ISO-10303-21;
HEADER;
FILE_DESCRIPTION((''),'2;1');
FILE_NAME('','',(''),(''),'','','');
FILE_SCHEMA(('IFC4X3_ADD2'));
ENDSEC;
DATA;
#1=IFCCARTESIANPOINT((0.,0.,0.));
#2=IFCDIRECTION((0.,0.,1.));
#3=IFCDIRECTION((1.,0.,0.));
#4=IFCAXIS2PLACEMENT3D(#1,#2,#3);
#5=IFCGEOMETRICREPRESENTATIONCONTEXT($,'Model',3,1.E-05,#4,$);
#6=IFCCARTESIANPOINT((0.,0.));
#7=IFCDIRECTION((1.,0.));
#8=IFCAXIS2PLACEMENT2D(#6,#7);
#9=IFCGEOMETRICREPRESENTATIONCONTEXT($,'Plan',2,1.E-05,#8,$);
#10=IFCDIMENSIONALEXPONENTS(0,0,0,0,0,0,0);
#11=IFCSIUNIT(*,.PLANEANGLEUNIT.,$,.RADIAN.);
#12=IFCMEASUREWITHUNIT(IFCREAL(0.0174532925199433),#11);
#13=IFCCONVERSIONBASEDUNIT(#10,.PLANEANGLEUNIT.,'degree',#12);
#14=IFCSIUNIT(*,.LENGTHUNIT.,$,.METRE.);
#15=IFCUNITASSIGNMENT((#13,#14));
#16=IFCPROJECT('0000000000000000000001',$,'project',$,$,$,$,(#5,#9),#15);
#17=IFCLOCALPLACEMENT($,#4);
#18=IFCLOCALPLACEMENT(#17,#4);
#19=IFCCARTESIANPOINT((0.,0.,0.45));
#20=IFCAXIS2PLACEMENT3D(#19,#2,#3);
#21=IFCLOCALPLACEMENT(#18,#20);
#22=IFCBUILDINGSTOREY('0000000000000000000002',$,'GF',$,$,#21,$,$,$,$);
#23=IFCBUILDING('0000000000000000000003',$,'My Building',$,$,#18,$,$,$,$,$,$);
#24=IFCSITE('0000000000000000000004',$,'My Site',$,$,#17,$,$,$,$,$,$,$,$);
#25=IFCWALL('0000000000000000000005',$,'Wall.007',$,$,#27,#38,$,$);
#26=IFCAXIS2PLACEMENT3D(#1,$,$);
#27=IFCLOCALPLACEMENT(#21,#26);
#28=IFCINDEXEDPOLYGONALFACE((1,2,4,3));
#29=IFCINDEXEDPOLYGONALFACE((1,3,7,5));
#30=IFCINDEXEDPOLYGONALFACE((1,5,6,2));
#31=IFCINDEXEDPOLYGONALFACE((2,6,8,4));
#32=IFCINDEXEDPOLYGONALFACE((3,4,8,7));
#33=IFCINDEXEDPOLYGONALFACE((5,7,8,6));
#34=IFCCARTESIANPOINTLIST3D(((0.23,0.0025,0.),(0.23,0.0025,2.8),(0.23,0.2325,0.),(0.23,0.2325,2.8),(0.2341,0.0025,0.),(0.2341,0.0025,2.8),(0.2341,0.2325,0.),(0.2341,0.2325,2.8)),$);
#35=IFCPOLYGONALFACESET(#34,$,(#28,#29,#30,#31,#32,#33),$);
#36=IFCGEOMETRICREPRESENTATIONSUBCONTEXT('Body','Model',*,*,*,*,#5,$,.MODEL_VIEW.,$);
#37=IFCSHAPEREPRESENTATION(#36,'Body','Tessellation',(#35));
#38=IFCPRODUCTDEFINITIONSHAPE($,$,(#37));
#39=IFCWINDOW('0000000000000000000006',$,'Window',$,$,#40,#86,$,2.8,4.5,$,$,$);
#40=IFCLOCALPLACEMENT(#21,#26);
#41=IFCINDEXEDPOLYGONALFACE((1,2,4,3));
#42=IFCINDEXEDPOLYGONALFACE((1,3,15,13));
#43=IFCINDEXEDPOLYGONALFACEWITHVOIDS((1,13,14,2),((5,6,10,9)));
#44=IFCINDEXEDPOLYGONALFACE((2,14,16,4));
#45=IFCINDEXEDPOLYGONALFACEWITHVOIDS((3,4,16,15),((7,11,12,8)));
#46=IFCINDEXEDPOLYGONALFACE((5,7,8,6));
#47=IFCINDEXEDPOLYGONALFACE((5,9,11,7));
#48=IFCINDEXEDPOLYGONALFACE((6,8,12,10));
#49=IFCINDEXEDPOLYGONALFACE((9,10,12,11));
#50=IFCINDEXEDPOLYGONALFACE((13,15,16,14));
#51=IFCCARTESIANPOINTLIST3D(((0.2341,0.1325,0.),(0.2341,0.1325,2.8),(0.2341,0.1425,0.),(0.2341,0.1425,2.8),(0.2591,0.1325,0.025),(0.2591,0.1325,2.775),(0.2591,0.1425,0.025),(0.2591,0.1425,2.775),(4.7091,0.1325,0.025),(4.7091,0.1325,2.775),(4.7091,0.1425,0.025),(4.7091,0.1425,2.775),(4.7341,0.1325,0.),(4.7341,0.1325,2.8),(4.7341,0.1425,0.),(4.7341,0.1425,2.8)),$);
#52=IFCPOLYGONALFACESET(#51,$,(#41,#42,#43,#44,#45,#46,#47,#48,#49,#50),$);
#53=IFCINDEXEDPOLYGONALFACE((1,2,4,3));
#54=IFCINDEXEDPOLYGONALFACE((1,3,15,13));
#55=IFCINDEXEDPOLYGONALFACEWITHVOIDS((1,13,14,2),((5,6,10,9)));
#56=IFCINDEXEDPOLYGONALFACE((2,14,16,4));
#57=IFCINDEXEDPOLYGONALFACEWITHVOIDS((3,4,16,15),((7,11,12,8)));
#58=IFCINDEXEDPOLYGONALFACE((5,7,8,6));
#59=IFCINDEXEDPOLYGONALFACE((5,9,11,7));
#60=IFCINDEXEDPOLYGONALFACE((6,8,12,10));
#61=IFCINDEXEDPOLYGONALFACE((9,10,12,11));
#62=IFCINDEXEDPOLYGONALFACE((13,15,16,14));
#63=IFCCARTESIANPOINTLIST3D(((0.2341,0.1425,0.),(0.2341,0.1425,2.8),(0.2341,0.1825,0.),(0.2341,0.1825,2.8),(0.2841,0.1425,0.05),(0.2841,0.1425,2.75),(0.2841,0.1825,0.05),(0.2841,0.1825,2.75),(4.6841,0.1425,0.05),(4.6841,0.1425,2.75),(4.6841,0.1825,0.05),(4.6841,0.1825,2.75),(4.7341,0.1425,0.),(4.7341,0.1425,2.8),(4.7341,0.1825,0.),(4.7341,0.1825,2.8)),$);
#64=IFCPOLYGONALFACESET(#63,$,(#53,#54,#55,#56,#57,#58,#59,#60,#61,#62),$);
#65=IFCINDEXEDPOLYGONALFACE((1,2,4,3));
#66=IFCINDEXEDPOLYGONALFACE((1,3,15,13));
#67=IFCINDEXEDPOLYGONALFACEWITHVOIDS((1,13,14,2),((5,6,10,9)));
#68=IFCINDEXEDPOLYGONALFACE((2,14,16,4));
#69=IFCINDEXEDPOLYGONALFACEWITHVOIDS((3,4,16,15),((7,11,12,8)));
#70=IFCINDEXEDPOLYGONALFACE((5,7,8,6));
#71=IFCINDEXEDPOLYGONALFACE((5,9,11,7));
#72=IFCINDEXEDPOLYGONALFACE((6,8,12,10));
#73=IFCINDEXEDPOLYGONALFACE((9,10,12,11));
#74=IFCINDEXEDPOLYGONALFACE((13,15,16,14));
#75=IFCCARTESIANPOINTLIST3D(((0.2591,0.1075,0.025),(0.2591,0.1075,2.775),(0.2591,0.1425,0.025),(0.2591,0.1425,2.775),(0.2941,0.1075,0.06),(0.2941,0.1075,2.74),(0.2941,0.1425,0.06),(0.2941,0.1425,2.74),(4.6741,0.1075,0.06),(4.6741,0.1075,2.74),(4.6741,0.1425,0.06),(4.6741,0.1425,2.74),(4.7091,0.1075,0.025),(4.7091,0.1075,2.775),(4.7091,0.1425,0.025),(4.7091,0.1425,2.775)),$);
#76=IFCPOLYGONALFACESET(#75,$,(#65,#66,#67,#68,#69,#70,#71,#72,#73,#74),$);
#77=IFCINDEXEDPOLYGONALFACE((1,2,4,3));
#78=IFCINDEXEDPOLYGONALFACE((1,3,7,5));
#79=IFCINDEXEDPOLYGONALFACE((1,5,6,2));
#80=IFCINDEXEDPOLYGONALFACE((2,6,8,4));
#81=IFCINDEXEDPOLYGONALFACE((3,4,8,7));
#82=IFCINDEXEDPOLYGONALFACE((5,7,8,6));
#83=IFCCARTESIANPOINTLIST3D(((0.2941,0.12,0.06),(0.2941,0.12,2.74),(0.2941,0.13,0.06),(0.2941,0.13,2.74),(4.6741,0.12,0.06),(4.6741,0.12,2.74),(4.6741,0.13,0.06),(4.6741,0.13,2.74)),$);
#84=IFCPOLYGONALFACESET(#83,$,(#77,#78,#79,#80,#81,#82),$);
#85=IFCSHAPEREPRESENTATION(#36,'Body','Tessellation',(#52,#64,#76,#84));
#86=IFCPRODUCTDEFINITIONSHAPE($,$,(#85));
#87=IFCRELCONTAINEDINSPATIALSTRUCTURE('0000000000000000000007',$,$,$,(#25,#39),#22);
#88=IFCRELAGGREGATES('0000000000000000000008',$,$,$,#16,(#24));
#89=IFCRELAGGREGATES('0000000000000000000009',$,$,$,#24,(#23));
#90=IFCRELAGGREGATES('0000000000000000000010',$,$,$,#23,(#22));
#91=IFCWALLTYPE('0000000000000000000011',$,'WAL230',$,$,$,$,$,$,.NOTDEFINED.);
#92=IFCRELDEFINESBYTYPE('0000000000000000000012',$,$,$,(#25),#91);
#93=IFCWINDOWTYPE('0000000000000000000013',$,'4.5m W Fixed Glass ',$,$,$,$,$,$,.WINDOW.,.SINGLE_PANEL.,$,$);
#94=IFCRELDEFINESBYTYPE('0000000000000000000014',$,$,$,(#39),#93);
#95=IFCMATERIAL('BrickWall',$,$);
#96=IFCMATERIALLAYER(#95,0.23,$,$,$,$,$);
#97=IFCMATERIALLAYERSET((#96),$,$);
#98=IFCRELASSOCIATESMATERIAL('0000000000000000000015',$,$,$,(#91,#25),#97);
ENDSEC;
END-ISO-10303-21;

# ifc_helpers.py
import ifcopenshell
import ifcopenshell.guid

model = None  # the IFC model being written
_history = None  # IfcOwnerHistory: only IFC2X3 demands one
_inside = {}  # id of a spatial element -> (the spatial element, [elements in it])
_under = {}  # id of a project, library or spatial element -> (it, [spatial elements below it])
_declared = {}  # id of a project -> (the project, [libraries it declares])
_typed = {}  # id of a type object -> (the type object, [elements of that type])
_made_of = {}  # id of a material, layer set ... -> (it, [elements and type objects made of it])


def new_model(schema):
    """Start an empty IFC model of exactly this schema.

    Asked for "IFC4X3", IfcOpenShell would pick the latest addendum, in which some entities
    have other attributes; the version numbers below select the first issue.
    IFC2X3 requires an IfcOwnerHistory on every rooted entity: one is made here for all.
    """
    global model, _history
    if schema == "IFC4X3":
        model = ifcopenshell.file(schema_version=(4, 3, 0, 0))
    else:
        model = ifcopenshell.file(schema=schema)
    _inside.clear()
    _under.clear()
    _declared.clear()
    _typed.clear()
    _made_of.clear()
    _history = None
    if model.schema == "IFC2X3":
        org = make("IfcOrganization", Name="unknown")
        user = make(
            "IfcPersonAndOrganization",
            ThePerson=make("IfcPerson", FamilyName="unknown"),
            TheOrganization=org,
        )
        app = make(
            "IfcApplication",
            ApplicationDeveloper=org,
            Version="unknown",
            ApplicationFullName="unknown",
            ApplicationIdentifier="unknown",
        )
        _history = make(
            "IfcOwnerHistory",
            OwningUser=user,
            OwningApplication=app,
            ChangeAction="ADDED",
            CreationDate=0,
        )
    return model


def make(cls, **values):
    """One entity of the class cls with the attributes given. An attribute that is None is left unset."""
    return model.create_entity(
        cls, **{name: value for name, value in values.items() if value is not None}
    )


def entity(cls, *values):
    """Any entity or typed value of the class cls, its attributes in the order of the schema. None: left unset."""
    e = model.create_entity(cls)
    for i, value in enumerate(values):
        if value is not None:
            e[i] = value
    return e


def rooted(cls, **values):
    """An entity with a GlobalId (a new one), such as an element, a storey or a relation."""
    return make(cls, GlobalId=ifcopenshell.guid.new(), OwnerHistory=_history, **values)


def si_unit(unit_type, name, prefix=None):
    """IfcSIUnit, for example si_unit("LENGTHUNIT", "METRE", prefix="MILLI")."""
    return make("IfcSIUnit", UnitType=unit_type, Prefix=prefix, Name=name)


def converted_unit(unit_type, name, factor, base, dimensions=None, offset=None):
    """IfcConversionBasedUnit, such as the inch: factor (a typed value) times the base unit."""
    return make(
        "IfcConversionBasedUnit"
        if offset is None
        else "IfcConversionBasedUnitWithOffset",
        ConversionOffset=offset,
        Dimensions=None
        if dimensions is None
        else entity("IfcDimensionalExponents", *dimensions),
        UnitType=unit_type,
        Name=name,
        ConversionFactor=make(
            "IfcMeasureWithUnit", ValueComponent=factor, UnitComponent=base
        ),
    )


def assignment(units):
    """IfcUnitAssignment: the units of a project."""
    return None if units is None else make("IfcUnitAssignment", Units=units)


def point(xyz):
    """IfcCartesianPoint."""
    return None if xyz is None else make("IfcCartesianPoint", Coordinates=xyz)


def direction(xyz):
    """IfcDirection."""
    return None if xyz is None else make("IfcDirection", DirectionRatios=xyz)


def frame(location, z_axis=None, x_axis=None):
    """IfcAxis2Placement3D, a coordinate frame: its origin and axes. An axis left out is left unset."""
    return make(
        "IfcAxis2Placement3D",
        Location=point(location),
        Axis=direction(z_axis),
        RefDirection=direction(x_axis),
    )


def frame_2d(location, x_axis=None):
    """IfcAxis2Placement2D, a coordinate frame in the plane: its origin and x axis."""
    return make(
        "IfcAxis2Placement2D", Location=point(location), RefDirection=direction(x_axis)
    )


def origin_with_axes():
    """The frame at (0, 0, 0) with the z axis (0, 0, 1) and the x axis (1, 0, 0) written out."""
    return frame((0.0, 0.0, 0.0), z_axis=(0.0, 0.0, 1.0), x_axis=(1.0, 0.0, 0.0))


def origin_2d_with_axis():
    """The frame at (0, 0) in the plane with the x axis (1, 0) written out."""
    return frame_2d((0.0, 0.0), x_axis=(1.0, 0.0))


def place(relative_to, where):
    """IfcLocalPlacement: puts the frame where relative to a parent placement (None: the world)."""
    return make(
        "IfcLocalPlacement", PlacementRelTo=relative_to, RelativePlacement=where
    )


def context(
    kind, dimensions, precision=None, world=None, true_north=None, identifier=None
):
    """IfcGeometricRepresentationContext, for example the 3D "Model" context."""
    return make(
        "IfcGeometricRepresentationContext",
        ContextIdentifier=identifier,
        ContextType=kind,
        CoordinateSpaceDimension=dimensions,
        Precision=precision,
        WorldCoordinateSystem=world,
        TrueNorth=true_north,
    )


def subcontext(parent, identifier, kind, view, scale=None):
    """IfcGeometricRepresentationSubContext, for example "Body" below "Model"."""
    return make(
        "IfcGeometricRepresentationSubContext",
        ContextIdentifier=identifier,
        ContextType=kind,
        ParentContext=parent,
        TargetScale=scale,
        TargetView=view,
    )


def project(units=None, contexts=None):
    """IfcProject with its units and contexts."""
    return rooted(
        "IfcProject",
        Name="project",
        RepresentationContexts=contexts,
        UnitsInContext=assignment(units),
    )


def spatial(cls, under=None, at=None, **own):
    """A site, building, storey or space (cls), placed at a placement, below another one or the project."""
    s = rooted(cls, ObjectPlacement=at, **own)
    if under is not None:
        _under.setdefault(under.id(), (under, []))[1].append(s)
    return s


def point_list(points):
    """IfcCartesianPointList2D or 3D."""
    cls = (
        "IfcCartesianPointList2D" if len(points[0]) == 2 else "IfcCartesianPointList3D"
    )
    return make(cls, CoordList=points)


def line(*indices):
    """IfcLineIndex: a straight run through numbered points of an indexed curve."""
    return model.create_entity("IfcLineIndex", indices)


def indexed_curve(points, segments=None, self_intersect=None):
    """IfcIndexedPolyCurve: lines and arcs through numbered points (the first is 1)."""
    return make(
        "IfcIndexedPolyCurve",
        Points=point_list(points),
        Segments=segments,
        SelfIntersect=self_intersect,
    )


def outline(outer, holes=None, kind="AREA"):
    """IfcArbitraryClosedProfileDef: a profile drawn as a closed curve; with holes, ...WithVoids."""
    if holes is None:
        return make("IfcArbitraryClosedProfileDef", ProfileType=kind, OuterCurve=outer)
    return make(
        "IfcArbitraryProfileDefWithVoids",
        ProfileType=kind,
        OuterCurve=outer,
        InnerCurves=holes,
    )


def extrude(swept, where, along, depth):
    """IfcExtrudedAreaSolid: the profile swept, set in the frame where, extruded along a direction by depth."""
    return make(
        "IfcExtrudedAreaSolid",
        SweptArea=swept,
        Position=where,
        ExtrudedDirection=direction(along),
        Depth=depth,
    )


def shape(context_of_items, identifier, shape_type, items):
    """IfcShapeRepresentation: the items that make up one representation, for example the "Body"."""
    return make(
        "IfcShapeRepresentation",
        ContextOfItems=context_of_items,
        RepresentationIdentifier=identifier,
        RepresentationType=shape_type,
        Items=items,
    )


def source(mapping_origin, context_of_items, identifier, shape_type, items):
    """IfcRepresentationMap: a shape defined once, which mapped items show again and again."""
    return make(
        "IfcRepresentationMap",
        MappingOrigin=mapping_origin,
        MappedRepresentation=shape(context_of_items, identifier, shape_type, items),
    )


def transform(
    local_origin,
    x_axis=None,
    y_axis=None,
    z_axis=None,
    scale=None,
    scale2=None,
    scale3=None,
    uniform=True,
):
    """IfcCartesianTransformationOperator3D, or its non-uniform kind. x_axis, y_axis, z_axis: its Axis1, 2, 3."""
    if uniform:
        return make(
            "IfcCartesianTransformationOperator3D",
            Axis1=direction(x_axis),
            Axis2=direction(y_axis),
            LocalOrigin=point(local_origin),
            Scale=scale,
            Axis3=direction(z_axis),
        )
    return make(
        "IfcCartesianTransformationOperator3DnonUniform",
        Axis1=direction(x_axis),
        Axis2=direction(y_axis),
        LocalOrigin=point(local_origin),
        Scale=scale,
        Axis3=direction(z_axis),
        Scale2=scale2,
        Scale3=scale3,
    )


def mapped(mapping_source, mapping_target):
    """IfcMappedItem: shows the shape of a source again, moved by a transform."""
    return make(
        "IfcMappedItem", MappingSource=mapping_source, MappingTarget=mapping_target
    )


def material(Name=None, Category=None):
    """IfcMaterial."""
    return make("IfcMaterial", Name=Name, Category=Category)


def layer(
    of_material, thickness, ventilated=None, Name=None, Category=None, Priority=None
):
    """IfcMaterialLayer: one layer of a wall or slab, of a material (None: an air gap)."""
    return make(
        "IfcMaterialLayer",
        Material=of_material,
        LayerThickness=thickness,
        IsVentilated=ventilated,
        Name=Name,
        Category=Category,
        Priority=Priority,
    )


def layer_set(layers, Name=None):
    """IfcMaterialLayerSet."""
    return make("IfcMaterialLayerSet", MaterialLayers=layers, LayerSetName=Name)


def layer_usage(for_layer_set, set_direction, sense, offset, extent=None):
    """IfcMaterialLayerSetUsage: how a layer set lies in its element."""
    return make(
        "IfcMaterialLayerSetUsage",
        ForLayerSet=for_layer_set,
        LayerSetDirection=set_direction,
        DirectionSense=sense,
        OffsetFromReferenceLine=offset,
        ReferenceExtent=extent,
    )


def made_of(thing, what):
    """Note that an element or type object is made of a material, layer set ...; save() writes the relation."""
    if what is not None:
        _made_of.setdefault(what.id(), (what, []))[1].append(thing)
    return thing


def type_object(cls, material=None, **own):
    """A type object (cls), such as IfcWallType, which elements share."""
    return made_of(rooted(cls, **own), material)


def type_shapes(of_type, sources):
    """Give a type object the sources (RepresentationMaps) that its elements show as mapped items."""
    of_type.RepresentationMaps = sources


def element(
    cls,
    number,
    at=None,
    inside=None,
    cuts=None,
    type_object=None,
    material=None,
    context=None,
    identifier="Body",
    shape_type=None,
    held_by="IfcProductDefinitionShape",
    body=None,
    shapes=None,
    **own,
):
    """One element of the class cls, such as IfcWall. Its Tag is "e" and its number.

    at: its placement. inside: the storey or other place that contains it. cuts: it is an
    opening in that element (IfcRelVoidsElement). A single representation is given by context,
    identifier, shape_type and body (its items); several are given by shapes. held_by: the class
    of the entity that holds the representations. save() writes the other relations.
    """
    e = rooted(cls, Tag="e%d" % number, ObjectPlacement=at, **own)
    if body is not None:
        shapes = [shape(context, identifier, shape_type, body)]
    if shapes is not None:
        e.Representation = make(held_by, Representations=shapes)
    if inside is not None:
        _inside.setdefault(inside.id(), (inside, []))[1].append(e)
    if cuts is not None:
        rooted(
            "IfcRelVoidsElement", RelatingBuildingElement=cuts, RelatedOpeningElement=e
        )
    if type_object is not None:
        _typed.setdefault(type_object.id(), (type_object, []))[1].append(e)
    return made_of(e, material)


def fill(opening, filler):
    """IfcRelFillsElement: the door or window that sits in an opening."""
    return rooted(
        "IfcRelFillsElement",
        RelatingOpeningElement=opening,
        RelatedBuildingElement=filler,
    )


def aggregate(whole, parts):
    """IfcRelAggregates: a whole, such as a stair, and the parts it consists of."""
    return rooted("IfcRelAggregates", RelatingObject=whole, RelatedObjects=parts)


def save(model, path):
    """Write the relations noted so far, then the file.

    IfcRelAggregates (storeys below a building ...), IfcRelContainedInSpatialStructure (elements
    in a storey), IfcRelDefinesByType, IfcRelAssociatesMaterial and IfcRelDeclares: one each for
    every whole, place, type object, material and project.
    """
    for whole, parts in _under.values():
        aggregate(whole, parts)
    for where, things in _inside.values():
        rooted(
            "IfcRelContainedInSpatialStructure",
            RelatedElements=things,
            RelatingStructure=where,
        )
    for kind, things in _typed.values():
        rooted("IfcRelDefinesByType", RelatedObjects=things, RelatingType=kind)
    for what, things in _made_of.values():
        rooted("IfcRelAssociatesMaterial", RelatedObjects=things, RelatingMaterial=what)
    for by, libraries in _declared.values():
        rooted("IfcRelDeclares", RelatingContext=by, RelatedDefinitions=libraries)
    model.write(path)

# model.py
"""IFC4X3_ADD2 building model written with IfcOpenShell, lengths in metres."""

from ifc_helpers import new_model, entity, si_unit, converted_unit, frame, origin_with_axes, origin_2d_with_axis, place, context, subcontext, project, spatial, line, indexed_curve, outline, extrude, shape, source, transform, mapped, material, layer, layer_set, layer_usage, type_object, type_shapes, element, fill, save


model = new_model("IFC4X3_ADD2")

# Units and contexts
model_context = context("Model", 3, precision=1e-05, world=origin_with_axes())
plan_context = context("Plan", 2, precision=1e-05, world=origin_2d_with_axis())
body_context_1 = subcontext(model_context, "Body", "Model", "MODEL_VIEW")
body_context_2 = subcontext(plan_context, "Body", "Plan", "PLAN_VIEW")
ifc_project = project(units=[converted_unit("PLANEANGLEUNIT", "degree", entity("IfcReal", 0.0174532925199433), si_unit("PLANEANGLEUNIT", "RADIAN"), dimensions=[0, 0, 0, 0, 0, 0, 0]), si_unit("LENGTHUNIT", "METRE")], contexts=[model_context, plan_context])

# Site, building, storey
site_placement = place(None, origin_with_axes())
site = spatial("IfcSite", under=ifc_project, at=site_placement, Name="My Site")
building_placement = place(site_placement, origin_with_axes())
building = spatial("IfcBuilding", under=site, at=building_placement, Name="My Building")
storey_placement = place(building_placement, frame((0.0, 0.0, 0.45), z_axis=(0.0, 0.0, 1.0), x_axis=(1.0, 0.0, 0.0)))
storey = spatial("IfcBuildingStorey", under=building, at=storey_placement, Name="GF")

# Shared definitions
ifc_material_1 = material(Name="BrickWall")

# Wall, opening, window
ifc_layer_1 = layer(ifc_material_1, 0.23)
ifc_layer_set_1 = layer_set([ifc_layer_1])
ifc_layer_usage_1 = layer_usage(ifc_layer_set_1, "AXIS2", "POSITIVE", 0.0)
wall_type_1 = type_object("IfcWallType", Name="WAL230", PredefinedType="NOTDEFINED", material=ifc_layer_set_1)
wall_1_placement = place(storey_placement, frame((0.2341, 0.2325, 0.0), z_axis=(0.0, 0.0, 1.0), x_axis=(-1.0, 0.0, 0.0)))
wall_1 = element("IfcWall", 1, at=wall_1_placement, inside=storey, type_object=wall_type_1, material=ifc_layer_usage_1, Name="Wall.007", context=body_context_1, shape_type="SweptSolid", body=[
    extrude(outline(indexed_curve([(0.0, 0.0), (0.0, 0.23), (0.0041, 0.23), (0.0041, 0.0), (0.0, 0.0)], self_intersect=False)), origin_with_axes(), (0.0, 0.0, 1.0), 2.8),
])
shared_shape_1 = source(origin_with_axes(), body_context_1, "Body", "SweptSolid", [
    extrude(outline(indexed_curve([(0.0, 0.0), (4.5, 0.0), (4.5, 2.8), (0.0, 2.8)], segments=[line(1, 2, 3, 4, 1)])), frame((0.0, -0.6, 0.0), z_axis=(0.0, -1.0, 0.0), x_axis=(1.0, 0.0, 0.0)), (0.0, 0.0, -1.0), 1.2),
])
opening_1_placement = place(wall_1_placement, frame((-4.5, 0.0, 0.0), z_axis=(0.0, 0.0, 1.0), x_axis=(1.0, 0.0, 0.0)))
opening_1 = element("IfcOpeningElement", 2, at=opening_1_placement, cuts=wall_1, PredefinedType="OPENING", context=body_context_1, shape_type="MappedRepresentation", body=[
    mapped(shared_shape_1, transform((0.0, 0.0, 0.0), x_axis=(1.0, 0.0, 0.0), y_axis=(0.0, 1.0, 0.0), z_axis=(0.0, 0.0, 1.0), scale=1.0)),
])
window_type_1 = type_object("IfcWindowType", Name="4.5m W Fixed Glass ", PartitioningType="SINGLE_PANEL", PredefinedType="WINDOW")
shared_shape_2 = source(origin_with_axes(), body_context_1, "Body", "SweptSolid", [
    extrude(outline(indexed_curve([(0.0, 0.0), (4.5, 0.0), (4.5, 2.8), (0.0, 2.8)], segments=[line(1, 2, 3, 4, 1)]), holes=[indexed_curve([(0.025, 0.025), (4.475, 0.025), (4.475, 2.775), (0.025, 2.775)], segments=[line(1, 2, 3, 4, 1)])]), frame((0.0, 0.09, 0.0), z_axis=(0.0, -1.0, 0.0), x_axis=(1.0, 0.0, 0.0)), (0.0, 0.0, -1.0), 0.01),
    extrude(outline(indexed_curve([(0.0, 0.0), (4.5, 0.0), (4.5, 2.8), (0.0, 2.8)], segments=[line(1, 2, 3, 4, 1)]), holes=[indexed_curve([(0.05, 0.05), (4.45, 0.05), (4.45, 2.75), (0.05, 2.75)], segments=[line(1, 2, 3, 4, 1)])]), frame((0.0, 0.05, 0.0), z_axis=(0.0, -1.0, 0.0), x_axis=(1.0, 0.0, 0.0)), (0.0, 0.0, -1.0), 0.04),
    extrude(outline(indexed_curve([(0.0, 0.0), (4.45, 0.0), (4.45, 2.75), (0.0, 2.75)], segments=[line(1, 2, 3, 4, 1)]), holes=[indexed_curve([(0.035, 0.035), (4.415, 0.035), (4.415, 2.715), (0.035, 2.715)], segments=[line(1, 2, 3, 4, 1)])]), frame((0.025, 0.09, 0.025), z_axis=(0.0, -1.0, 0.0), x_axis=(1.0, 0.0, 0.0)), (0.0, 0.0, -1.0), 0.035),
    extrude(outline(indexed_curve([(0.035, 0.035), (4.415, 0.035), (4.415, 2.715), (0.035, 2.715)], segments=[line(1, 2, 3, 4, 1)])), frame((0.025, 0.1025, 0.025), z_axis=(0.0, -1.0, 0.0), x_axis=(1.0, 0.0, 0.0)), (0.0, 0.0, -1.0), 0.01),
])
shared_shape_3 = source(origin_with_axes(), body_context_2, "Body", "Curve2D", [
    entity("IfcIndexedPolyCurve", entity("IfcCartesianPointList2D", [[0.05, 0.05], [4.45, 0.05]])),
    entity("IfcIndexedPolyCurve", entity("IfcCartesianPointList2D", [[0.0, 0.1], [0.025, 0.1], [0.025, 0.09], [0.05, 0.09], [0.05, 0.05], [0.0, 0.05]]), [entity("IfcLineIndex", [1, 2, 3, 4, 5, 6, 1])]),
    entity("IfcIndexedPolyCurve", entity("IfcCartesianPointList2D", [[4.5, 0.1], [4.475, 0.1], [4.475, 0.09], [4.45, 0.09], [4.45, 0.05], [4.5, 0.05]]), [entity("IfcLineIndex", [1, 2, 3, 4, 5, 6, 1])]),
    entity("IfcIndexedPolyCurve", entity("IfcCartesianPointList2D", [[0.025, 0.09], [0.06, 0.09], [0.06, 0.125], [0.025, 0.125]]), [entity("IfcLineIndex", [1, 2, 3, 4, 1])]),
    entity("IfcIndexedPolyCurve", entity("IfcCartesianPointList2D", [[4.475, 0.09], [4.44, 0.09], [4.44, 0.125], [4.475, 0.125]]), [entity("IfcLineIndex", [1, 2, 3, 4, 1])]),
    entity("IfcIndexedPolyCurve", entity("IfcCartesianPointList2D", [[0.06, 0.09], [4.44, 0.09]])),
    entity("IfcIndexedPolyCurve", entity("IfcCartesianPointList2D", [[0.06, 0.125], [4.44, 0.125]])),
    entity("IfcIndexedPolyCurve", entity("IfcCartesianPointList2D", [[0.06, 0.1075], [4.44, 0.1075]])),
])
type_shapes(window_type_1, [shared_shape_2, shared_shape_3])
window_1_placement = place(opening_1_placement, frame((0.0, 0.0, 0.0), z_axis=(0.0, 0.0, 1.0), x_axis=(1.0, 0.0, 0.0)))
window_1 = element("IfcWindow", 3, at=window_1_placement, inside=storey, type_object=window_type_1, Name="Window", OverallHeight=2.8, OverallWidth=4.5, shapes=[
    shape(body_context_1, "Body", "MappedRepresentation", [mapped(shared_shape_2, transform((0.0, 0.0, 0.0), x_axis=(1.0, 0.0, 0.0), y_axis=(0.0, 1.0, 0.0), z_axis=(0.0, 0.0, 1.0), scale=1.0))]),
    shape(body_context_2, "Body", "MappedRepresentation", [mapped(shared_shape_3, transform((0.0, 0.0, 0.0), x_axis=(1.0, 0.0, 0.0), y_axis=(0.0, 1.0, 0.0), z_axis=(0.0, 0.0, 1.0), scale=1.0))]),
])
fill(opening_1, window_1)

save(model, "model.ifc")
